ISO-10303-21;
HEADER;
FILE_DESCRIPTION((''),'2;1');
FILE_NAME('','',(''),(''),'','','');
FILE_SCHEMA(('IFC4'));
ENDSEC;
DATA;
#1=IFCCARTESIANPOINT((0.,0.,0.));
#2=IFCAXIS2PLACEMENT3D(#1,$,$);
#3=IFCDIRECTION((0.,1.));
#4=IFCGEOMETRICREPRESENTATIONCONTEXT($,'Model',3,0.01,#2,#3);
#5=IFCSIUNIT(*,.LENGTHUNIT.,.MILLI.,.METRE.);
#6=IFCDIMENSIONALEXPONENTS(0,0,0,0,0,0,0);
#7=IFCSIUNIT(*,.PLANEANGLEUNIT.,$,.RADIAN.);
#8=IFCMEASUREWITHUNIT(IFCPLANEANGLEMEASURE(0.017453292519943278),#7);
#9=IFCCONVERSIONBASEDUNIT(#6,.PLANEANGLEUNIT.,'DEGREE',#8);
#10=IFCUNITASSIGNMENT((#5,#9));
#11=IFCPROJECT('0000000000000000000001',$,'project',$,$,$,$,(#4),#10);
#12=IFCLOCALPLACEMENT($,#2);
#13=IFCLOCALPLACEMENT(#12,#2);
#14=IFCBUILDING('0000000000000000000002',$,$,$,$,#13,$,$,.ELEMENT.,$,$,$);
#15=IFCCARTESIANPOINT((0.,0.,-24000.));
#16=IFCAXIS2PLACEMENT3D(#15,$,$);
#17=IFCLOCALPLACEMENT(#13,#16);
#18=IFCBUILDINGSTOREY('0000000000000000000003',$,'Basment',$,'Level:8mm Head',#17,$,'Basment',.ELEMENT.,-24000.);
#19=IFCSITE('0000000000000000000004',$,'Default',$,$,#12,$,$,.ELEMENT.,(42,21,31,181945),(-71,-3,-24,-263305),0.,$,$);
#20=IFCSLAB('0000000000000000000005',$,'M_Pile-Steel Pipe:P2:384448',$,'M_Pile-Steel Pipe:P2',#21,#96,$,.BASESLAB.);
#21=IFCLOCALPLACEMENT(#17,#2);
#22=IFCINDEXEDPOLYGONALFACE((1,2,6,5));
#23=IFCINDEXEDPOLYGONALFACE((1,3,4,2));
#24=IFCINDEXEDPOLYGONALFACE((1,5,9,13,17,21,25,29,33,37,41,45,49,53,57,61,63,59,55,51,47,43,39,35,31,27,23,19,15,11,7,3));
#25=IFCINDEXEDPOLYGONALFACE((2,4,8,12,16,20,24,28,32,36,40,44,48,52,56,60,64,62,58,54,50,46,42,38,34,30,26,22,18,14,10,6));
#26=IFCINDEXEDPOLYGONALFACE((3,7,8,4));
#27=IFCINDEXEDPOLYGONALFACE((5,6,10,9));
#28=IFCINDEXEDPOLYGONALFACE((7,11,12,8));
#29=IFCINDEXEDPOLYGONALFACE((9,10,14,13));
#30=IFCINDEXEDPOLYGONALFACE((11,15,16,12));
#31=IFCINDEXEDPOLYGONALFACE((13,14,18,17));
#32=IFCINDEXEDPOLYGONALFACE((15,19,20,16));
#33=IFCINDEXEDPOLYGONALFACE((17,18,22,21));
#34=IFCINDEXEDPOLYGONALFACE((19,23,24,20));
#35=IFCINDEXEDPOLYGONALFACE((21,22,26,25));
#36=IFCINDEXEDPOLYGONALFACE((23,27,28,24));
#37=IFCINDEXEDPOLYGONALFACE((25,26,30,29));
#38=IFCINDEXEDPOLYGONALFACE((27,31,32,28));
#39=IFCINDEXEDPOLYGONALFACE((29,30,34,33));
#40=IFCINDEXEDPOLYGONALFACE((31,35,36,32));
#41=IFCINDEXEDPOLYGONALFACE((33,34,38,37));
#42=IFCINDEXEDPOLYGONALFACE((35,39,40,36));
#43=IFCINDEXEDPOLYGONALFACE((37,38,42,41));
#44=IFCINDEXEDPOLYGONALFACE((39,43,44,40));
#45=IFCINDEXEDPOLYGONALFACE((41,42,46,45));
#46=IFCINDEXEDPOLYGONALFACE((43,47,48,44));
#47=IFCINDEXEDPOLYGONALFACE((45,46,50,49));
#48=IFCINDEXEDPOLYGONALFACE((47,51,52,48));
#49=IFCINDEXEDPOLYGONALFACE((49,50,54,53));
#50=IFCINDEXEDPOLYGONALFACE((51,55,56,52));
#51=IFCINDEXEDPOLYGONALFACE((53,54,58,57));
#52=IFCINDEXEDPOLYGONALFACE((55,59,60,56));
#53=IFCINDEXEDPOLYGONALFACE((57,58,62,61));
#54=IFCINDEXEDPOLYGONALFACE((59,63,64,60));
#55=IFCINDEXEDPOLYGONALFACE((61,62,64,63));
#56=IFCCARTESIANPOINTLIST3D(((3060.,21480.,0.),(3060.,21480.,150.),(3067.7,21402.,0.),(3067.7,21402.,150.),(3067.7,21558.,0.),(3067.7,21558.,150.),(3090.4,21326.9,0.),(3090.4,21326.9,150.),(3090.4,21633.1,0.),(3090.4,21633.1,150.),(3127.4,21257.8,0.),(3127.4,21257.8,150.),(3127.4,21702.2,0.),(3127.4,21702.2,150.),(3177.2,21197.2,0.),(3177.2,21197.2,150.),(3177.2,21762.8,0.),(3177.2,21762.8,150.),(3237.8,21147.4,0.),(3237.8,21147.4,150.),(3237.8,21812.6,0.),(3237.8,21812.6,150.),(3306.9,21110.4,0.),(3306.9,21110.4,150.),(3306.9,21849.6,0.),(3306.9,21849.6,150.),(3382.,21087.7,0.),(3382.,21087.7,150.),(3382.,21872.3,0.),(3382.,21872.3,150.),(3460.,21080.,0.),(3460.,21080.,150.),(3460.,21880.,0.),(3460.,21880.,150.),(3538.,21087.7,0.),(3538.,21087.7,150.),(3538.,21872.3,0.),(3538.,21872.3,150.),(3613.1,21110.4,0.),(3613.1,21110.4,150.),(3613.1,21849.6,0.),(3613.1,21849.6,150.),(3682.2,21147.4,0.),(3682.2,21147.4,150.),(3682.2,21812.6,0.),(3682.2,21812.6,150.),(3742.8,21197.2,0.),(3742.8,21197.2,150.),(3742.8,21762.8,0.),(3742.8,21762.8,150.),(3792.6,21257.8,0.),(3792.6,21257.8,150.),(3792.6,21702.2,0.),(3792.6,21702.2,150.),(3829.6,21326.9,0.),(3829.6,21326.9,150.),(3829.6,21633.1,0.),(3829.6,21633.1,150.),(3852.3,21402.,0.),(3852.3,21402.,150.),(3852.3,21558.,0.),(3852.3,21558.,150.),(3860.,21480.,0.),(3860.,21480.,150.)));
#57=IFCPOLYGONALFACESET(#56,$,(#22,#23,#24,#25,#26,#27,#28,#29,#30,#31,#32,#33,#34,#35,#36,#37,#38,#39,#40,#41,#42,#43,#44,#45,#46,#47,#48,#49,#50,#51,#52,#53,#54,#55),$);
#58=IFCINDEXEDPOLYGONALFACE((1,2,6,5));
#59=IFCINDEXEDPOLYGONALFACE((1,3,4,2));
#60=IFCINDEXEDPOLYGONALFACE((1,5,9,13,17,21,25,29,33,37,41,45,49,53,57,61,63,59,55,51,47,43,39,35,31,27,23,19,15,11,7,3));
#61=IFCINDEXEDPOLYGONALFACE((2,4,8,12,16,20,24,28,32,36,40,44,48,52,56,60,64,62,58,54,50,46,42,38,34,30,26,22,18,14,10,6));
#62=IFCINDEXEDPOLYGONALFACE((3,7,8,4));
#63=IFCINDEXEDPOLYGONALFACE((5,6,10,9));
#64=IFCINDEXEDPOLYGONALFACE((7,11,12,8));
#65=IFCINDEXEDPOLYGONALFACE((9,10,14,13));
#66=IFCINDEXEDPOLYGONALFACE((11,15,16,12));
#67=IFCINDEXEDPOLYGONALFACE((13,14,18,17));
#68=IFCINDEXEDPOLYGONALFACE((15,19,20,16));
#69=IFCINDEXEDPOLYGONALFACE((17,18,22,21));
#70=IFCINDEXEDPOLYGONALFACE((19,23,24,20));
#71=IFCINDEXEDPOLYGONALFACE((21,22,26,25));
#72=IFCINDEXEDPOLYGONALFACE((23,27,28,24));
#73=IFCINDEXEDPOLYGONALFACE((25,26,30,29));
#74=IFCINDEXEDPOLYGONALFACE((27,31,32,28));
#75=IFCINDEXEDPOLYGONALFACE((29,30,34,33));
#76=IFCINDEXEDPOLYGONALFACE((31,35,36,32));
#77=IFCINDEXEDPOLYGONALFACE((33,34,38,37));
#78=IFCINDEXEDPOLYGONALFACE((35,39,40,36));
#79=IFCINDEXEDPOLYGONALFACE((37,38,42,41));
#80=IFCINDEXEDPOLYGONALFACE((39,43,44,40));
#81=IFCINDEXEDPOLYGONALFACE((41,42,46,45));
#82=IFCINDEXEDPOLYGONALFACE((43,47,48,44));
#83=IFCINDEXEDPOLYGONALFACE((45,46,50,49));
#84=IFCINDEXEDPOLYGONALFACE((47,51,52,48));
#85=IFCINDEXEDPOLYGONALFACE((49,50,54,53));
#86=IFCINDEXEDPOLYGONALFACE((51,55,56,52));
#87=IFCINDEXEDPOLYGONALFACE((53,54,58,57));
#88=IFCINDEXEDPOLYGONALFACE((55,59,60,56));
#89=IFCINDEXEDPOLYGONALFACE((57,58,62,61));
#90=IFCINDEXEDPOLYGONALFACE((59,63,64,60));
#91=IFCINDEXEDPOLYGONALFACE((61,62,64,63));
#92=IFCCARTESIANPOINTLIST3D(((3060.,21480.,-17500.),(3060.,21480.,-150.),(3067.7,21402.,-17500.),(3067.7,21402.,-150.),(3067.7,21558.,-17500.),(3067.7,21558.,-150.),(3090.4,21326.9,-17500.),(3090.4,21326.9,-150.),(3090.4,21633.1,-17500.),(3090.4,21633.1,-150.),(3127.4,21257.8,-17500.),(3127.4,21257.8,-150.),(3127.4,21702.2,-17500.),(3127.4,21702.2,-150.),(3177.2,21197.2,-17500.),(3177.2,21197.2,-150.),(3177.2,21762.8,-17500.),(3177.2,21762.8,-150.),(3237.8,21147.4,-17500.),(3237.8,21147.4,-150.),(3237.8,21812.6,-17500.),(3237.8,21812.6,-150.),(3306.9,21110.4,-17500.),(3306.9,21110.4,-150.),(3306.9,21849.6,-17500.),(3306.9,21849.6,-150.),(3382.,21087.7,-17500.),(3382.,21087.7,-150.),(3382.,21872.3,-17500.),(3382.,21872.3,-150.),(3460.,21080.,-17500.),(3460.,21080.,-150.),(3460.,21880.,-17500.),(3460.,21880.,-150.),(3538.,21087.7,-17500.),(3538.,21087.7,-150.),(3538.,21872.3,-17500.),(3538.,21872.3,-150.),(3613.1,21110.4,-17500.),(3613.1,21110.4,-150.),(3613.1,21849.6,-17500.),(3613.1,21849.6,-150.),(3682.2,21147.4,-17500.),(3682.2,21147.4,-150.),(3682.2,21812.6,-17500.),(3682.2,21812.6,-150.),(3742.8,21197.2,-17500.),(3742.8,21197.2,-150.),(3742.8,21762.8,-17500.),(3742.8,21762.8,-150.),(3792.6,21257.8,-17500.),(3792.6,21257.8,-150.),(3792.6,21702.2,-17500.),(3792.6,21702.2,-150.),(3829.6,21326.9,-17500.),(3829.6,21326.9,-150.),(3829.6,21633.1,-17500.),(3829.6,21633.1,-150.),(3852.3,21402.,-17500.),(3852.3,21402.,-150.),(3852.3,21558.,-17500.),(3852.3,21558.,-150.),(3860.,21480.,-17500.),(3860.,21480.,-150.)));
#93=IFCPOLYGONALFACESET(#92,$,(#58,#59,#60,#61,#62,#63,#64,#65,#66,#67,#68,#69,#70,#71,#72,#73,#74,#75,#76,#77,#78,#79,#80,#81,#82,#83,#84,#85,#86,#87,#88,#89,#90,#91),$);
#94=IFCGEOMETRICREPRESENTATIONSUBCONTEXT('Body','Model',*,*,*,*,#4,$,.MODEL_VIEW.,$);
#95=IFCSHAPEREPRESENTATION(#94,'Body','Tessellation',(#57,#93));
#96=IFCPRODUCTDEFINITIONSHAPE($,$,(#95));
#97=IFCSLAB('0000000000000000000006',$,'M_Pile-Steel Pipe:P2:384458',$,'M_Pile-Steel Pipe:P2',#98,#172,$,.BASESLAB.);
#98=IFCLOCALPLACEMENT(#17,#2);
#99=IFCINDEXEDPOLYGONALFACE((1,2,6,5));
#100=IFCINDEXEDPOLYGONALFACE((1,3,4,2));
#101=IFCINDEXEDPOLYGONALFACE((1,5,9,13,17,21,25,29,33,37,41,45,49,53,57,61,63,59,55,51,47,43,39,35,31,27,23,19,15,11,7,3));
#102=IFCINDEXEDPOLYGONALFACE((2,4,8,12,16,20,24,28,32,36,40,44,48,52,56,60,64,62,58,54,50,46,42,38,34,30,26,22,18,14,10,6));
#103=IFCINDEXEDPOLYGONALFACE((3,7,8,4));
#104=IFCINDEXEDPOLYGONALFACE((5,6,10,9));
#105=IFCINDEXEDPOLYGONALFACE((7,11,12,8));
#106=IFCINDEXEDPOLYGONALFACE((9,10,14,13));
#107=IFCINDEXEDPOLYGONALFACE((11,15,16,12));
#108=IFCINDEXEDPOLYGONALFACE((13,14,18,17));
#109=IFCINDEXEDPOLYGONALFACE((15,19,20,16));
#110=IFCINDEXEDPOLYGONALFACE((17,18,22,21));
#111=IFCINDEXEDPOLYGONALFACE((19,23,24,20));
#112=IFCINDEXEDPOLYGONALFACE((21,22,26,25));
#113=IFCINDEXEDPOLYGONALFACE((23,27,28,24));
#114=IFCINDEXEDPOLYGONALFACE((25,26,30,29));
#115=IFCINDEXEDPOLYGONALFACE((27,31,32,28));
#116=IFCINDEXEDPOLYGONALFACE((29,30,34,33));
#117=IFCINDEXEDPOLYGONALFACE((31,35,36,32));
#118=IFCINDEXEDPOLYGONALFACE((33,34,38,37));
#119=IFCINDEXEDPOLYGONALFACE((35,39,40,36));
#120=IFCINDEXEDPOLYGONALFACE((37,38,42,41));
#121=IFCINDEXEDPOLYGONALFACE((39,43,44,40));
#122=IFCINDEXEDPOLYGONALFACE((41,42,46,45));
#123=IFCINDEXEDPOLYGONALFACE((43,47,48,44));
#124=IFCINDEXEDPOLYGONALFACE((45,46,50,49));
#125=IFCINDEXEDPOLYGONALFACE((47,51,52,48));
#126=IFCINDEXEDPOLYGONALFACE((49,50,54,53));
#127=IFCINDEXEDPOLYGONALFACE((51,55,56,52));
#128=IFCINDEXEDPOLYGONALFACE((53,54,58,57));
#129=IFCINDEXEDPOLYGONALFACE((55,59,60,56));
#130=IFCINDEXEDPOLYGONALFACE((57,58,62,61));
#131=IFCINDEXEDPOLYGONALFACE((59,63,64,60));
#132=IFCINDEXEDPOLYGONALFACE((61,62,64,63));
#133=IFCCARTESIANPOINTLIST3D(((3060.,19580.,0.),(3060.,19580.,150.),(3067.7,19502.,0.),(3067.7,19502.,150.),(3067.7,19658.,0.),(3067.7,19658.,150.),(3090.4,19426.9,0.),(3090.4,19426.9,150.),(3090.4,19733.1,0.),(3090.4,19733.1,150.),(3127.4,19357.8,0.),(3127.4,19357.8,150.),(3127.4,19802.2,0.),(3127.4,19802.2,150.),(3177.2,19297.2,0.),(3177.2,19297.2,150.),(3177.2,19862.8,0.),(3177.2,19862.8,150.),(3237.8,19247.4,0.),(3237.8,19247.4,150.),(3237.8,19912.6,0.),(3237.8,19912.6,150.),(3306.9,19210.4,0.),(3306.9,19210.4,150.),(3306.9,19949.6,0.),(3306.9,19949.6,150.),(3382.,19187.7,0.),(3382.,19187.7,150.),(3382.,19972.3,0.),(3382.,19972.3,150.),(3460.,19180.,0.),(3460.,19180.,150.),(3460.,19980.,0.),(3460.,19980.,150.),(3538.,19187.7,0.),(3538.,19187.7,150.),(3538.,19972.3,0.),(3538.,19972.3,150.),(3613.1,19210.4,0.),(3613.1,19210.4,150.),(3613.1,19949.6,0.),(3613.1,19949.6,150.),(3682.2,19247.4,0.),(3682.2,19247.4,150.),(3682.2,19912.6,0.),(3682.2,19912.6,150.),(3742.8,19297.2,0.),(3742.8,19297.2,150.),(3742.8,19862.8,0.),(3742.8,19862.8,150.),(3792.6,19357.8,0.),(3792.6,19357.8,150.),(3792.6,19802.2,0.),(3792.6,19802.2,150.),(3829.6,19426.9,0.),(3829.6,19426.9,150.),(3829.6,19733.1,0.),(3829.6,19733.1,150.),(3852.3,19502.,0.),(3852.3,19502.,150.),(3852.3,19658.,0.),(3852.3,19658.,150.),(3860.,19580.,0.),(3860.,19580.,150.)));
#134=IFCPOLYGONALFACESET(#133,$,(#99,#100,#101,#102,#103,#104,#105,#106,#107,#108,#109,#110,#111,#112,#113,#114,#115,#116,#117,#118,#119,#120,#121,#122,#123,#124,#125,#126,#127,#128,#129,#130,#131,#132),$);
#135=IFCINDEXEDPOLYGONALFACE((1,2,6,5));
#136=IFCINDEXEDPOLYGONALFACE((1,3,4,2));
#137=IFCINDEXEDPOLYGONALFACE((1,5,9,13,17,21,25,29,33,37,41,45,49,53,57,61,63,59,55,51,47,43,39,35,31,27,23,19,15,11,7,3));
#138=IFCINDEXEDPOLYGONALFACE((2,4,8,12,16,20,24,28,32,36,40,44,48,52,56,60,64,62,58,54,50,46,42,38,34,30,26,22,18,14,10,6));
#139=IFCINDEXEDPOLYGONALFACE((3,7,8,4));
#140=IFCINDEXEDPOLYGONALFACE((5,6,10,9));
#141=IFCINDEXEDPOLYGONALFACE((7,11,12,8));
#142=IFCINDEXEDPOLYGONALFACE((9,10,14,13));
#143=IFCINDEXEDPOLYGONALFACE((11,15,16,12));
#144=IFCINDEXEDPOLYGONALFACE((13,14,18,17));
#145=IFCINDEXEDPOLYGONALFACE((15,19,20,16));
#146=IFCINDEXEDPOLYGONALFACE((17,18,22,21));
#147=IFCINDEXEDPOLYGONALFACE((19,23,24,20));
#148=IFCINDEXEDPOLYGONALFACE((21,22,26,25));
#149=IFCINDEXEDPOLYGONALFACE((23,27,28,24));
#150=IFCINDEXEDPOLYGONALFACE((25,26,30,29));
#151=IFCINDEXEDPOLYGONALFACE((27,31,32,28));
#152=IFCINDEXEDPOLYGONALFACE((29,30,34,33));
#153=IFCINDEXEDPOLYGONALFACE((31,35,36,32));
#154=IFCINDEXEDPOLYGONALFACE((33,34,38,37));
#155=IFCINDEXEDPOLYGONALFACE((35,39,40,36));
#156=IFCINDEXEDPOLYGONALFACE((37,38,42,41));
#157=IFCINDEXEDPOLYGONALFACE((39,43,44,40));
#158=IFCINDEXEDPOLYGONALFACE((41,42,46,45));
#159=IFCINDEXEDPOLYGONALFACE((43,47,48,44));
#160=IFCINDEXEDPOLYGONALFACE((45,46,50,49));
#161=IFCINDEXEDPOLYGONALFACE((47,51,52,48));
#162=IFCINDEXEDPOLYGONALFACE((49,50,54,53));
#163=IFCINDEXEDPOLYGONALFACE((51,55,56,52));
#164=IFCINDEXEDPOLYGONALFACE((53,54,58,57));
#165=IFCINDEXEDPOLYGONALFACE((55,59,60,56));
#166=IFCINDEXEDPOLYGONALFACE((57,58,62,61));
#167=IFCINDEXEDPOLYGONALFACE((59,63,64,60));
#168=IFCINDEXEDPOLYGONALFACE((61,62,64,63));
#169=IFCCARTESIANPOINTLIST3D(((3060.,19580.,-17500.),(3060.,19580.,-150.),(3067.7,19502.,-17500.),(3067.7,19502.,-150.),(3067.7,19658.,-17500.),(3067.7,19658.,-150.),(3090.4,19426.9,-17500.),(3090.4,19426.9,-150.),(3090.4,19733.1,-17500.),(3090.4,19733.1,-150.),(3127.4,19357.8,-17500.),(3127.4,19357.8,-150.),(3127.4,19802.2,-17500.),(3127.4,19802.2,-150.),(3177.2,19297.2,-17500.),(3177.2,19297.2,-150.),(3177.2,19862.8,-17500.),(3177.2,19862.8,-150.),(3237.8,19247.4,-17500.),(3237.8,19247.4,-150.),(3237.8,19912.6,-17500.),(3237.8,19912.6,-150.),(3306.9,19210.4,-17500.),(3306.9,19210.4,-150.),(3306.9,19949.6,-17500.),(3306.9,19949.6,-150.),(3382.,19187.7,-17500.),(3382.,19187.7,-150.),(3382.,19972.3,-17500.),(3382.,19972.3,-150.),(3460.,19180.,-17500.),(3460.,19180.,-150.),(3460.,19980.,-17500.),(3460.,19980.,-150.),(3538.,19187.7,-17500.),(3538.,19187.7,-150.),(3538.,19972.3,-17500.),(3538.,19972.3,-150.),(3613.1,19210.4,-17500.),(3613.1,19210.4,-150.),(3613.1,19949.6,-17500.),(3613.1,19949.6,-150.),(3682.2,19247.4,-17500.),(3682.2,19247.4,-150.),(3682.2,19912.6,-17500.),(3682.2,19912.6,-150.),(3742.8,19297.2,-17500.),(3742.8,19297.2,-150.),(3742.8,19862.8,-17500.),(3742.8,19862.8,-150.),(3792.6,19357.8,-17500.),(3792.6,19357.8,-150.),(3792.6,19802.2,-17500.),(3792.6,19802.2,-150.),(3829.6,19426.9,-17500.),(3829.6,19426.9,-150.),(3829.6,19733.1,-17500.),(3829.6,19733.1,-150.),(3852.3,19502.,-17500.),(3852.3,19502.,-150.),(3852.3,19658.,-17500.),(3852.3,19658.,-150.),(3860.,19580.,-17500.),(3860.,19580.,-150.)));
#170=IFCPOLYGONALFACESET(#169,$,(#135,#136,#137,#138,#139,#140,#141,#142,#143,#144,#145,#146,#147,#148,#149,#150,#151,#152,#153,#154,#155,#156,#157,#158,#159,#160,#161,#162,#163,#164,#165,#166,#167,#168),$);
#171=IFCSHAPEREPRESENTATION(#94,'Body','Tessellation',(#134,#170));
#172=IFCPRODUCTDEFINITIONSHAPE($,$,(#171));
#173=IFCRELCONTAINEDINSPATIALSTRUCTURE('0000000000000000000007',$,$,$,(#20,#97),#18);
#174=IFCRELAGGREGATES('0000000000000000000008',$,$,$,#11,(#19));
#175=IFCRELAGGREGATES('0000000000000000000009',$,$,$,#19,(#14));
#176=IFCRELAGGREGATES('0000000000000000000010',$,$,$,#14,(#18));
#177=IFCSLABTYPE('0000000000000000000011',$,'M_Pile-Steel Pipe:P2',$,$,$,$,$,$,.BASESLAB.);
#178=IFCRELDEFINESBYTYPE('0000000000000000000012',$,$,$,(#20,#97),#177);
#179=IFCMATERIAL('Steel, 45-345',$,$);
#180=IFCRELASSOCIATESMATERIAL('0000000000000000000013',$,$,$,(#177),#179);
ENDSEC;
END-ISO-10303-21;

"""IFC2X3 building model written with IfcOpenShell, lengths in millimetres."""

from ifc_helpers import new_model, entity, si_unit, converted_unit, direction, frame, frame_2d, origin, place, context, subcontext, project, spatial, circle, extrude, material, type_object, element, save


model = new_model("IFC2X3")

# Units and contexts
model_context = context("Model", 3, precision=0.01, world=origin(), true_north=direction((0.0, 1.0)))
body_context = subcontext(model_context, "Body", "Model", "MODEL_VIEW")
ifc_project = project(units=[si_unit("LENGTHUNIT", "METRE", prefix="MILLI"), converted_unit("PLANEANGLEUNIT", "DEGREE", entity("IfcPlaneAngleMeasure", 0.017453292519943278), si_unit("PLANEANGLEUNIT", "RADIAN"), dimensions=[0, 0, 0, 0, 0, 0, 0])], contexts=[model_context])

# Site, building, storey
site_placement = place(None, origin())
site = spatial("IfcSite", under=ifc_project, at=site_placement, Name="Default", CompositionType="ELEMENT", RefLatitude=(42, 21, 31, 181945), RefLongitude=(-71, -3, -24, -263305), RefElevation=0.0)
building_placement = place(site_placement, origin())
building = spatial("IfcBuilding", under=site, at=building_placement, CompositionType="ELEMENT")
storey_placement = place(building_placement, frame((0.0, 0.0, -24000.0)))
storey = spatial("IfcBuildingStorey", under=building, at=storey_placement, Name="Basment", ObjectType="Level:8mm Head", LongName="Basment", CompositionType="ELEMENT", Elevation=-24000.0)

# Slabs
ifc_material_1 = material(Name="Steel, 45-345")
slab_type_1 = type_object("IfcSlabType", Name="M_Pile-Steel Pipe:P2", PredefinedType="BASESLAB", material=ifc_material_1)
slab_1_placement = place(storey_placement, origin())
element("IfcSlab", 1, at=slab_1_placement, inside=storey, type_object=slab_type_1, Name="M_Pile-Steel Pipe:P2:384448", ObjectType="M_Pile-Steel Pipe:P2", PredefinedType="BASESLAB", context=body_context, shape_type="SweptSolid", body=[
    extrude(circle(Radius=400.0, at=frame_2d((0.0, 0.0), x_axis=(1.0, 0.0))), frame((3460.0, 21480.0, 0.0), z_axis=(0.0, 0.0, 1.0), x_axis=(0.0, 1.0, 0.0)), (0.0, 0.0, 1.0), 150.0),
    extrude(circle(Radius=400.0, at=frame_2d((0.0, 0.0), x_axis=(1.0, 0.0))), frame((3460.0, 21480.0, -17500.0), z_axis=(0.0, 0.0, 1.0), x_axis=(0.0, 1.0, 0.0)), (0.0, 0.0, 1.0), 17350.0),
])
slab_2_placement = place(storey_placement, origin())
element("IfcSlab", 2, at=slab_2_placement, inside=storey, type_object=slab_type_1, Name="M_Pile-Steel Pipe:P2:384458", ObjectType="M_Pile-Steel Pipe:P2", PredefinedType="BASESLAB", context=body_context, shape_type="SweptSolid", body=[
    extrude(circle(Radius=400.0, at=frame_2d((0.0, 0.0), x_axis=(1.0, 0.0))), frame((3460.0, 19580.0, 0.0), z_axis=(0.0, 0.0, 1.0), x_axis=(0.0, 1.0, 0.0)), (0.0, 0.0, 1.0), 150.0),
    extrude(circle(Radius=400.0, at=frame_2d((0.0, 0.0), x_axis=(1.0, 0.0))), frame((3460.0, 19580.0, -17500.0), z_axis=(0.0, 0.0, 1.0), x_axis=(0.0, 1.0, 0.0)), (0.0, 0.0, 1.0), 17350.0),
])

save(model, "model.ifc")
